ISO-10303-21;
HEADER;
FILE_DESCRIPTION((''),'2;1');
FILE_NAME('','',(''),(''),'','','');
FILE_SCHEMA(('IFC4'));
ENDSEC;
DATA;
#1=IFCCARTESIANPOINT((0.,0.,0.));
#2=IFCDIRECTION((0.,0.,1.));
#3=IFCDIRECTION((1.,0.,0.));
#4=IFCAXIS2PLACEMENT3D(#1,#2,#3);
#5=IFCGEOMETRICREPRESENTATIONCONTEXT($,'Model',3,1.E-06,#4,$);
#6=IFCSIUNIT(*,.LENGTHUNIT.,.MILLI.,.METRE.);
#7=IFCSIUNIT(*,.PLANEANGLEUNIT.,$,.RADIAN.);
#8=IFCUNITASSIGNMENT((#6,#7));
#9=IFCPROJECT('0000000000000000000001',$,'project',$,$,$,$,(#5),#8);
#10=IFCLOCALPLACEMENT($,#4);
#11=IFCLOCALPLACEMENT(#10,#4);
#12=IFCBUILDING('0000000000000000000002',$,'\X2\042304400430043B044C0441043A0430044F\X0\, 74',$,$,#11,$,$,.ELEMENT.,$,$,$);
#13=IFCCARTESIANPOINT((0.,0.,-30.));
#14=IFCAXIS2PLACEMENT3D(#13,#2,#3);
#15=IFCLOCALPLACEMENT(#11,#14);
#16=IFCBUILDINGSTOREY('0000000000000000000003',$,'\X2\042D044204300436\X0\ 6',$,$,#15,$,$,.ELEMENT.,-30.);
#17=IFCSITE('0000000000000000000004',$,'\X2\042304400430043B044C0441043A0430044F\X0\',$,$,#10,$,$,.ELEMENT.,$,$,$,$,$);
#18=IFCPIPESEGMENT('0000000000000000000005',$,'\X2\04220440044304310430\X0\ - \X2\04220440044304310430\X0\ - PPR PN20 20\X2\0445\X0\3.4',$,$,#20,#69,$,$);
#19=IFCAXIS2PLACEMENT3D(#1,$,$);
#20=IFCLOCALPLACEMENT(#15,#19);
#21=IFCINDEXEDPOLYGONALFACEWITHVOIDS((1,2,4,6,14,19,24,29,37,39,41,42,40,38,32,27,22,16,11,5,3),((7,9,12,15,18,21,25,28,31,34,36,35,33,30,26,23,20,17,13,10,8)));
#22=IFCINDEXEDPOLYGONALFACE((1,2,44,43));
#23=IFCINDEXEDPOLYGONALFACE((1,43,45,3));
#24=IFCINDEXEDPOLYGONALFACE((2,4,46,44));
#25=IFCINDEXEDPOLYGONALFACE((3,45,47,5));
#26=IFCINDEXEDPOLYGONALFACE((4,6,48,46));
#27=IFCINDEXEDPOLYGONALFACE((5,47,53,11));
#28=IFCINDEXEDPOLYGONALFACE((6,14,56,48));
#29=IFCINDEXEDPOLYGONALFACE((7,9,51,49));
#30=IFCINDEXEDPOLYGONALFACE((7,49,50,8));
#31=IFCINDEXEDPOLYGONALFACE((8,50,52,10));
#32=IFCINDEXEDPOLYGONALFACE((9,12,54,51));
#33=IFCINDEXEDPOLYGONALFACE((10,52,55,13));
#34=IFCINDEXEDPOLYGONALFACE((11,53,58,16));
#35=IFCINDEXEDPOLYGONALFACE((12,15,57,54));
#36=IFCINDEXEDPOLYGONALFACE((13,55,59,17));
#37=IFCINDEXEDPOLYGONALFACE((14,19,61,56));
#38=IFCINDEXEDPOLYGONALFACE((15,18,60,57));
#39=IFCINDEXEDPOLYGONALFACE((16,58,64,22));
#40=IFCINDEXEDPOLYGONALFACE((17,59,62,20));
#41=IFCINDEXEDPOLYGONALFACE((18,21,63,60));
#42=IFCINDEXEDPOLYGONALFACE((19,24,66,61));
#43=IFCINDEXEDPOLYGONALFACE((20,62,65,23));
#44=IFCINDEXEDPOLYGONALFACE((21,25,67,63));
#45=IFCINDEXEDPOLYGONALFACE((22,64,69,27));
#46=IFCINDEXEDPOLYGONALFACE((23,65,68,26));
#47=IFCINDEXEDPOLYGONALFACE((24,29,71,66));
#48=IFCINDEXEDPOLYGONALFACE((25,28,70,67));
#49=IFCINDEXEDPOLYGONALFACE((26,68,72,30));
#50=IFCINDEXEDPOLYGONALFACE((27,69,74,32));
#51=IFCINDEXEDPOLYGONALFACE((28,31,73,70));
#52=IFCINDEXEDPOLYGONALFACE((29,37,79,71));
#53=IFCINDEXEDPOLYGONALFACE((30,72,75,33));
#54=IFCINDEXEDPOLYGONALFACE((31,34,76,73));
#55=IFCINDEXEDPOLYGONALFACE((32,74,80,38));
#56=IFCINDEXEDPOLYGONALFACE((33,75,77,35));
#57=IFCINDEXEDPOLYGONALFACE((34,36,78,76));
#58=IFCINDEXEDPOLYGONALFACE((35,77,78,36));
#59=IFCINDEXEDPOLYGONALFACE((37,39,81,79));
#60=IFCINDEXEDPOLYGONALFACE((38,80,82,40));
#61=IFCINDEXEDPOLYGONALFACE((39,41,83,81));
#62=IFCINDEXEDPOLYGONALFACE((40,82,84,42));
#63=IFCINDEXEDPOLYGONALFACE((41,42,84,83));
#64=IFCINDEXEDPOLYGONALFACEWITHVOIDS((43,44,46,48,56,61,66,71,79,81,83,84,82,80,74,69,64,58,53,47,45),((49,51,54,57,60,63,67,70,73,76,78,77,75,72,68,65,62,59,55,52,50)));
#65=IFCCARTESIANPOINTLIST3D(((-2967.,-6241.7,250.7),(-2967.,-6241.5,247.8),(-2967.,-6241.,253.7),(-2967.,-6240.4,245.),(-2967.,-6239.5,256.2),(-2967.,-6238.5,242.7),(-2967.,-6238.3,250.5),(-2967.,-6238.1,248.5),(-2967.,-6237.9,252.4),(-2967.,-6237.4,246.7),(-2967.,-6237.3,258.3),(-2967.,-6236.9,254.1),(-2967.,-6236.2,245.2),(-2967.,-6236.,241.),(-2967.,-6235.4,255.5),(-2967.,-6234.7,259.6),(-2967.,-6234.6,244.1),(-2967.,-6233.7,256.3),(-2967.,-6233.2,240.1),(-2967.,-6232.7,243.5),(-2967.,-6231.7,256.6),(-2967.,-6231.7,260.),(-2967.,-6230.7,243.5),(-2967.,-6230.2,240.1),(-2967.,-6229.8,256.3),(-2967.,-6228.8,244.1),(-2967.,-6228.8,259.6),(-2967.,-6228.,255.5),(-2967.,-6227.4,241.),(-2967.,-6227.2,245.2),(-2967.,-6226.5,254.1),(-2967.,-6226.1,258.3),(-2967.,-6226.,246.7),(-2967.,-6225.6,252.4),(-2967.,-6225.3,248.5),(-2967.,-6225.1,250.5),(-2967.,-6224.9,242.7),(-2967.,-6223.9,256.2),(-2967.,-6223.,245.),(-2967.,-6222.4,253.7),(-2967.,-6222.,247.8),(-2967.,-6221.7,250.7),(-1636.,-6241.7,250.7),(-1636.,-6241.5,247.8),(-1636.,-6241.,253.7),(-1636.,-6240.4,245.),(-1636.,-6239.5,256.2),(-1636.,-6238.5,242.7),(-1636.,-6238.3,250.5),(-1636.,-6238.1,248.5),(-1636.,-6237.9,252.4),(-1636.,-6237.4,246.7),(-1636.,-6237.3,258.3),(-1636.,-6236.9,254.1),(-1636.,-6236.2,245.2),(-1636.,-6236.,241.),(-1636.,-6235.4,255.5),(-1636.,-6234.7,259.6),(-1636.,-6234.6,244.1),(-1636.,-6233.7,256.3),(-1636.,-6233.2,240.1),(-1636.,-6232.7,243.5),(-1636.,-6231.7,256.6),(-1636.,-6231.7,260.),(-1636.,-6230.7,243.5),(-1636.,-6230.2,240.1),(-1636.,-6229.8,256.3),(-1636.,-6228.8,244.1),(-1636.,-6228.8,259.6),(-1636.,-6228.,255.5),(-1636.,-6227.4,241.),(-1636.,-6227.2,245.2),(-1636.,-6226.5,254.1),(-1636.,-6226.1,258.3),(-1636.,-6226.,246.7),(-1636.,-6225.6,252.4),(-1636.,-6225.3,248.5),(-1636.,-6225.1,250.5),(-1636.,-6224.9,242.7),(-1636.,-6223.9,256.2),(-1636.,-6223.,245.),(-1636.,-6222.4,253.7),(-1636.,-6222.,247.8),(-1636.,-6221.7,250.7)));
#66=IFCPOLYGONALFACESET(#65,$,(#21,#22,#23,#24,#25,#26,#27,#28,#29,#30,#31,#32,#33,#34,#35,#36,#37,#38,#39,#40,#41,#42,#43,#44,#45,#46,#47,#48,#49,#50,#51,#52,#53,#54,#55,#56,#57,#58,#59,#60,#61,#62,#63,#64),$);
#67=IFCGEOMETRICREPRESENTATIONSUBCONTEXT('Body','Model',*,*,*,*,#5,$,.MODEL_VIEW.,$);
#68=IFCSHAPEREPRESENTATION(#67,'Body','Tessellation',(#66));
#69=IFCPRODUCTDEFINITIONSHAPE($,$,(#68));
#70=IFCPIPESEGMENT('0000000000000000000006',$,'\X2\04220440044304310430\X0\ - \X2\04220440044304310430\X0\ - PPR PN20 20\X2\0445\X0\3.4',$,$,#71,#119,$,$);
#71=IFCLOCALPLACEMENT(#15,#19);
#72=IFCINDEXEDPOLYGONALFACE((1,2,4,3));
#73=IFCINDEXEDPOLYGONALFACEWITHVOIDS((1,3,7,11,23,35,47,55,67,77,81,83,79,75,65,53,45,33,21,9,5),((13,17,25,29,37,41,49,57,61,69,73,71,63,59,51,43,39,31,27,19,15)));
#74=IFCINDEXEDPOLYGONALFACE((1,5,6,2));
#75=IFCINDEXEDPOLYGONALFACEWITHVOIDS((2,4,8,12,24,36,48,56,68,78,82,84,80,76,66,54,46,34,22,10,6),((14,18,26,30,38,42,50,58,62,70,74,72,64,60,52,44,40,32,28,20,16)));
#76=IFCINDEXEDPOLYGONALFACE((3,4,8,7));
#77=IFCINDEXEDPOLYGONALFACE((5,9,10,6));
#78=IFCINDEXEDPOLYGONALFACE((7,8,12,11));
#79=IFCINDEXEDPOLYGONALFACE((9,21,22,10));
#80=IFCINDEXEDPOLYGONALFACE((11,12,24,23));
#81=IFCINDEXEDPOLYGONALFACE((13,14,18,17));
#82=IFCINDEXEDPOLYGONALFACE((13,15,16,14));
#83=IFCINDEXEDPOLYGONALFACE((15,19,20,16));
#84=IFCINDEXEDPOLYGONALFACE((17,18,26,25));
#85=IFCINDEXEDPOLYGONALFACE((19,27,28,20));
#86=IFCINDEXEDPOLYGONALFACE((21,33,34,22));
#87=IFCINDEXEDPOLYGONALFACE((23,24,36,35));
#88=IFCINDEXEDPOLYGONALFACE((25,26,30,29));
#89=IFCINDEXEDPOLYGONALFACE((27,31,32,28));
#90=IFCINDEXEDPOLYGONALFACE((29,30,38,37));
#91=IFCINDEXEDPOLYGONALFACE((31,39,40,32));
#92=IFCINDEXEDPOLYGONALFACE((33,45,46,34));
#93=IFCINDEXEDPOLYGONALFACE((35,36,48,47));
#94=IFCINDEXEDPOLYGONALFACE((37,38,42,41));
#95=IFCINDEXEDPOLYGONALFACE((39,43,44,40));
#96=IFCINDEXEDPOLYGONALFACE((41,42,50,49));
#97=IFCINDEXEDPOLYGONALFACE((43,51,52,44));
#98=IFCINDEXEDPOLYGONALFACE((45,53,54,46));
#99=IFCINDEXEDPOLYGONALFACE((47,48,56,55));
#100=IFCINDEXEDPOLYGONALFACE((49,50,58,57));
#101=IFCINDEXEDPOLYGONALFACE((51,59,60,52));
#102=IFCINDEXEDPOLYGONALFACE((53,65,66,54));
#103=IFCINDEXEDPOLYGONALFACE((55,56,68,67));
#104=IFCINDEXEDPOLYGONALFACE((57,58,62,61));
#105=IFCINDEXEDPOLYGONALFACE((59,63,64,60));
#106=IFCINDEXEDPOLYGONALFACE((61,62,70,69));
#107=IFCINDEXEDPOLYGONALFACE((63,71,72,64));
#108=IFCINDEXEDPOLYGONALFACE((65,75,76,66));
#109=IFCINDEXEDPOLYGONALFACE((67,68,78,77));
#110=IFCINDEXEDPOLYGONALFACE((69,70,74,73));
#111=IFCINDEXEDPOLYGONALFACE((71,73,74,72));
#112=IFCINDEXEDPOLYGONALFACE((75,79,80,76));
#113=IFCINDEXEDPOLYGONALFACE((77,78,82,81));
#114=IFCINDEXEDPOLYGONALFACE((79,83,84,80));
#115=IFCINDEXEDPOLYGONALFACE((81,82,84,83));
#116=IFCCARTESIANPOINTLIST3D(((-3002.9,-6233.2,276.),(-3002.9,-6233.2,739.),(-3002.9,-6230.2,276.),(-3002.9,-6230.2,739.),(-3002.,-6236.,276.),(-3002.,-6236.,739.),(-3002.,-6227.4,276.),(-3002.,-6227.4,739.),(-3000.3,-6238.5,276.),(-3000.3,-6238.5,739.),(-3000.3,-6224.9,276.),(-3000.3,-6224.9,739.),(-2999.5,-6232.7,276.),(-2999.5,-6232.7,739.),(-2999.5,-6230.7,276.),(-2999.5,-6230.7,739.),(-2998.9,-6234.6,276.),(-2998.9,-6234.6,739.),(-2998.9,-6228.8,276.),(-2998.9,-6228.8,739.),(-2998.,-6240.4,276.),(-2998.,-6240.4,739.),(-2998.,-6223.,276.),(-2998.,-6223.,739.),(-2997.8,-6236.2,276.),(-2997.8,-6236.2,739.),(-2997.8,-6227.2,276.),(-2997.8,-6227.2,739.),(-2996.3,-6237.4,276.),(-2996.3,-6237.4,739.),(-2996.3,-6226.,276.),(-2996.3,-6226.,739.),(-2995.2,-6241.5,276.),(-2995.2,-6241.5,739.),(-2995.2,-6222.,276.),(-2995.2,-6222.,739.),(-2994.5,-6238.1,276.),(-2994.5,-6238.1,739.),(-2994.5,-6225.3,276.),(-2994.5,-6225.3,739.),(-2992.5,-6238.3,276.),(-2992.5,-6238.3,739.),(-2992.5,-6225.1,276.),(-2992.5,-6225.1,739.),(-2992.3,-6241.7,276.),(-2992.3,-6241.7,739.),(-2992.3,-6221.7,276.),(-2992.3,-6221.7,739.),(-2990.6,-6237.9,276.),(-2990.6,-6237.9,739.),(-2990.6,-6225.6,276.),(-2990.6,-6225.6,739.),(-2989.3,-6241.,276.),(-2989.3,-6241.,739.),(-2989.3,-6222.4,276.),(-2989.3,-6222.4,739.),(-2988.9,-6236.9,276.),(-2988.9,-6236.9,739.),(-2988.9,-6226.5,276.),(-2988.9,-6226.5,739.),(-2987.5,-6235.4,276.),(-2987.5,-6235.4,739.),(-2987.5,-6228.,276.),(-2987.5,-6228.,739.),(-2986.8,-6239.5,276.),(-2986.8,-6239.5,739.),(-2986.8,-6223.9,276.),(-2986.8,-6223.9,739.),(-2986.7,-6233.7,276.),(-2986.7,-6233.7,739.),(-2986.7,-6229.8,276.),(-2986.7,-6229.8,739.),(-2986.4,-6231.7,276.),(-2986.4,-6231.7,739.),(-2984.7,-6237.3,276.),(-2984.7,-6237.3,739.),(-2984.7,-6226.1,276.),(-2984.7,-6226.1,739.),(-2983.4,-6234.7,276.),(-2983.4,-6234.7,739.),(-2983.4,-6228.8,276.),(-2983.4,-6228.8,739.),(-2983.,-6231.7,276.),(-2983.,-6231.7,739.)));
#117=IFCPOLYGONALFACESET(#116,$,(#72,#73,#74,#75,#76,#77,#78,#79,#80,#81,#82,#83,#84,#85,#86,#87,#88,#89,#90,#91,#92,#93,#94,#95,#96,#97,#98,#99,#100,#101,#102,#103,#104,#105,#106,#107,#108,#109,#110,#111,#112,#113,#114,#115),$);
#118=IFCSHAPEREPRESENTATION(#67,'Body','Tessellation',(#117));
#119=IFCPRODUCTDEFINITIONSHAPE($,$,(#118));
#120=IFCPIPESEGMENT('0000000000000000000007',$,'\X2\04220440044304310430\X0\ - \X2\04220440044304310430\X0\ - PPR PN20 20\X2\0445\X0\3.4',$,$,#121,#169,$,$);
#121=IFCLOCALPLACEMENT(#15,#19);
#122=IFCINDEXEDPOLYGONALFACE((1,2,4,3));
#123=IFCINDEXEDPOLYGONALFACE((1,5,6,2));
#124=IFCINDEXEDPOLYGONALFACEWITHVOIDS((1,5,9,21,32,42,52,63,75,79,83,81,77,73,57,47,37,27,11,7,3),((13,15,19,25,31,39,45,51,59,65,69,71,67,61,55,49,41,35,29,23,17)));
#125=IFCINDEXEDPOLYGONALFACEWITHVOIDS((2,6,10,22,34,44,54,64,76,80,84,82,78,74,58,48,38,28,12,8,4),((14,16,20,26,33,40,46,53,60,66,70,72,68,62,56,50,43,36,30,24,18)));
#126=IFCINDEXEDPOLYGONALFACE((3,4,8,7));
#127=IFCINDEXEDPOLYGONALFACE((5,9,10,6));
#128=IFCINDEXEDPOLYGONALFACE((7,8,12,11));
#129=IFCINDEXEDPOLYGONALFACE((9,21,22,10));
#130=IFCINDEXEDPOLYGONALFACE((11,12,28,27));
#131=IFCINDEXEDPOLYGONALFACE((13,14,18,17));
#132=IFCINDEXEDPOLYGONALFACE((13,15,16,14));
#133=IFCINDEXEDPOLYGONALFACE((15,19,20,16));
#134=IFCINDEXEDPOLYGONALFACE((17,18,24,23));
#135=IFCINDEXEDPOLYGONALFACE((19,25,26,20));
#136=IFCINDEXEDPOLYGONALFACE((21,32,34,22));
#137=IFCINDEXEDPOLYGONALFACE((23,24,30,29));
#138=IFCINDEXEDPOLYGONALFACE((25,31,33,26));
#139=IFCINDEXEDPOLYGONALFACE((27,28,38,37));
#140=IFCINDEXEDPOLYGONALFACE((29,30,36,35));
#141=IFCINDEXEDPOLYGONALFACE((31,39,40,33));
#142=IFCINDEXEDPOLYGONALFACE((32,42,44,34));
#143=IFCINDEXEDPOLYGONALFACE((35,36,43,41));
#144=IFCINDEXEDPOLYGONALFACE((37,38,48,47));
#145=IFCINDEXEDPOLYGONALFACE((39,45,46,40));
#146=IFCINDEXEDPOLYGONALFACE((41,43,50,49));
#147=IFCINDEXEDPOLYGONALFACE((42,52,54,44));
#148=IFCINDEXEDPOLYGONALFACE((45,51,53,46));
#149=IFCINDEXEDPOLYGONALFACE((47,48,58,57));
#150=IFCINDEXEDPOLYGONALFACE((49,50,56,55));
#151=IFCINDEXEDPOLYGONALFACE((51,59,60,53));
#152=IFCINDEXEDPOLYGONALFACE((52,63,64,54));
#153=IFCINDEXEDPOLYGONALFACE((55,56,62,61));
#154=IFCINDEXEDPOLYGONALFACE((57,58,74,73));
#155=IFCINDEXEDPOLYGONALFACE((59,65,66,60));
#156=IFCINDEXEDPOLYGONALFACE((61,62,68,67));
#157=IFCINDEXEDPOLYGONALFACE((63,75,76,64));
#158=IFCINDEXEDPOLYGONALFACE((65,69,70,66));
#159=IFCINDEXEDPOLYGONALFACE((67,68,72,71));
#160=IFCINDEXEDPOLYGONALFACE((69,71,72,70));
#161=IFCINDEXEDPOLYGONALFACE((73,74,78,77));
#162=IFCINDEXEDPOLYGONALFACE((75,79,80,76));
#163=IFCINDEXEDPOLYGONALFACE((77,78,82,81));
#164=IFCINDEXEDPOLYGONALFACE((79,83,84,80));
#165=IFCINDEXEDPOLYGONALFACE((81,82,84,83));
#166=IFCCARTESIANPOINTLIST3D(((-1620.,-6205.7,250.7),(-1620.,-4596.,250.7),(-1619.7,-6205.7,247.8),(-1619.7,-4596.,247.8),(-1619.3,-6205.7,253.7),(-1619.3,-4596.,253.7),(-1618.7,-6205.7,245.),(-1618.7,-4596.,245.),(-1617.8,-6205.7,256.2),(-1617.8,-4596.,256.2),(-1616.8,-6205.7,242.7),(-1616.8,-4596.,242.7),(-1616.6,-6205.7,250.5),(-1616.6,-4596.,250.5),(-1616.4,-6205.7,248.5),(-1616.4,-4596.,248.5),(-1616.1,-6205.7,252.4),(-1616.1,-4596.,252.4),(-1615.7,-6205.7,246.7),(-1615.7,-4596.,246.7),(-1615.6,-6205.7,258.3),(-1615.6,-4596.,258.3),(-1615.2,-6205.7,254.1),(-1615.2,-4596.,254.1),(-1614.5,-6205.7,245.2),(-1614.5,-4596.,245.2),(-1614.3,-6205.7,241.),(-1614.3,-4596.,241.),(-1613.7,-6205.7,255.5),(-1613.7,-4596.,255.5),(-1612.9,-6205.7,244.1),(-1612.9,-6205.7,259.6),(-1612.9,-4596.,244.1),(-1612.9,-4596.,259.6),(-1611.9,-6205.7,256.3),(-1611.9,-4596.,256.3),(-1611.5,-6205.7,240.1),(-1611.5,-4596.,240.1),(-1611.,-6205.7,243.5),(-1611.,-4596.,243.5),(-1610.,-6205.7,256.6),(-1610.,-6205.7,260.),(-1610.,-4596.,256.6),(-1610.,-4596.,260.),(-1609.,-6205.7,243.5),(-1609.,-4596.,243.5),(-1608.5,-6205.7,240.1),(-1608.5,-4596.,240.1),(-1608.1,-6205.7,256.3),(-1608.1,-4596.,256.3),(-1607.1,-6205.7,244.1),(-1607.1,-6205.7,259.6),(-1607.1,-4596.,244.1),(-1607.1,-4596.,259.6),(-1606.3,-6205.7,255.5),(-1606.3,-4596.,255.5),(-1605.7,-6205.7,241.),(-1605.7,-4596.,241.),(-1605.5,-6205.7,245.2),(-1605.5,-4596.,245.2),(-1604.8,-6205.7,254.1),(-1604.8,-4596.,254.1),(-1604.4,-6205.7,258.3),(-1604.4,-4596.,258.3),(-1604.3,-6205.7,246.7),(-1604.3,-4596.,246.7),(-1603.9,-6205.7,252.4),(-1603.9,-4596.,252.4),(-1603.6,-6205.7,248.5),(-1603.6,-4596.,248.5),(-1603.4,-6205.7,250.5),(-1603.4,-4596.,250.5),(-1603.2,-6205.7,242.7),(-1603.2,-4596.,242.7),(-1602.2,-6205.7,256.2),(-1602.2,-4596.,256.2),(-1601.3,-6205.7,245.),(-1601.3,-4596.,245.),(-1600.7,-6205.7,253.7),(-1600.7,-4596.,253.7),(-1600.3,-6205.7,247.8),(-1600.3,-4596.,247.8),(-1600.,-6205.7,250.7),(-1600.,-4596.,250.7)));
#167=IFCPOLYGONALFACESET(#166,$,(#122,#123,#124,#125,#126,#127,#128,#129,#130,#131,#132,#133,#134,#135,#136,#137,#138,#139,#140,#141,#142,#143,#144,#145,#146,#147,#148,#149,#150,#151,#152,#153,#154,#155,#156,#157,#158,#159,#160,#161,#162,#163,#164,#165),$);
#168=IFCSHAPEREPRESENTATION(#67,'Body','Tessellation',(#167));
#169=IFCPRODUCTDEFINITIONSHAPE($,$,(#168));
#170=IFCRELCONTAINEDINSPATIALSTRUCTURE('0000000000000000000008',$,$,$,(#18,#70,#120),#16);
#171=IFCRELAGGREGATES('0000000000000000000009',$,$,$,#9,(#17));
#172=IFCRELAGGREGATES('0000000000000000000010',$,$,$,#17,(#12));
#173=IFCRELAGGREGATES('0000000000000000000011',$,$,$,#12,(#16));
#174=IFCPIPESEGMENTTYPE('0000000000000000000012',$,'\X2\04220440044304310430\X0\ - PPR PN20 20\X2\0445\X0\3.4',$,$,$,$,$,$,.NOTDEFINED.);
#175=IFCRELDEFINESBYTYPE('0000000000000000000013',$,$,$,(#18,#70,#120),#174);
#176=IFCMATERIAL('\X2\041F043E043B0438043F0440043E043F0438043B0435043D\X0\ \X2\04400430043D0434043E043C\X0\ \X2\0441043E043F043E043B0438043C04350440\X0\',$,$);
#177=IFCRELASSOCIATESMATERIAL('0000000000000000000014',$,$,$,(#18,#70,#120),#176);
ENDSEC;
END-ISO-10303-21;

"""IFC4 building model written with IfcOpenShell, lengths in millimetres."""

from ifc_helpers import new_model, entity, si_unit, frame, origin_with_axes, place, context, subcontext, project, spatial, material, type_object, element, save


model = new_model("IFC4")

# Units and contexts
model_context = context("Model", 3, precision=1e-06, world=origin_with_axes())
body_context = subcontext(model_context, "Body", "Model", "MODEL_VIEW")
ifc_project = project(units=[si_unit("LENGTHUNIT", "METRE", prefix="MILLI"), si_unit("PLANEANGLEUNIT", "RADIAN")], contexts=[model_context])

# Site, building, storey
site_placement = place(None, origin_with_axes())
site = spatial("IfcSite", under=ifc_project, at=site_placement, Name="Уральская", CompositionType="ELEMENT")
building_placement = place(site_placement, origin_with_axes())
building = spatial("IfcBuilding", under=site, at=building_placement, Name="Уральская, 74", CompositionType="ELEMENT")
storey_placement = place(building_placement, frame((0.0, 0.0, -30.0), z_axis=(0.0, 0.0, 1.0), x_axis=(1.0, 0.0, 0.0)))
storey = spatial("IfcBuildingStorey", under=building, at=storey_placement, Name="Этаж 6", CompositionType="ELEMENT", Elevation=-30.0)

# Pipe segments
ifc_material_1 = material(Name="Полипропилен рандом сополимер")
pipe_segment_type_1 = type_object("IfcPipeSegmentType", Name="Труба - PPR PN20 20х3.4", PredefinedType="NOTDEFINED")
pipe_segment_1_placement = place(storey_placement, frame((-2967.0, -6231.7, 250.0), z_axis=(0.0, 0.0, 1.0), x_axis=(1.0, 0.0, 0.0)))
element("IfcPipeSegment", 1, at=pipe_segment_1_placement, inside=storey, type_object=pipe_segment_type_1, material=ifc_material_1, Name="Труба - Труба - PPR PN20 20х3.4", context=body_context, shape_type="AdvancedSweptSolid", body=[
    entity("IfcSweptDiskSolid", entity("IfcIndexedPolyCurve", entity("IfcCartesianPointList3D", [[0.0, 0.0, 0.0], [1331.0, 0.0, 0.0]]), [entity("IfcLineIndex", [1, 2])]), 10.0, 6.6),
])
pipe_segment_2_placement = place(storey_placement, frame((-2993.0, -6231.7, 739.0), z_axis=(0.0, 0.0, 1.0), x_axis=(-1.0, 0.0, 0.0)))
element("IfcPipeSegment", 2, at=pipe_segment_2_placement, inside=storey, type_object=pipe_segment_type_1, material=ifc_material_1, Name="Труба - Труба - PPR PN20 20х3.4", context=body_context, shape_type="AdvancedSweptSolid", body=[
    entity("IfcSweptDiskSolid", entity("IfcIndexedPolyCurve", entity("IfcCartesianPointList3D", [[0.0, 0.0, 0.0], [0.0, 0.0, -463.0]]), [entity("IfcLineIndex", [1, 2])]), 10.0, 6.6),
])
pipe_segment_3_placement = place(storey_placement, frame((-1610.0, -6205.7, 250.0), z_axis=(0.0, 0.0, 1.0), x_axis=(0.0, 1.0, 0.0)))
element("IfcPipeSegment", 3, at=pipe_segment_3_placement, inside=storey, type_object=pipe_segment_type_1, material=ifc_material_1, Name="Труба - Труба - PPR PN20 20х3.4", context=body_context, shape_type="AdvancedSweptSolid", body=[
    entity("IfcSweptDiskSolid", entity("IfcIndexedPolyCurve", entity("IfcCartesianPointList3D", [[0.0, 0.0, 0.0], [1609.7, 0.0, 0.0]]), [entity("IfcLineIndex", [1, 2])]), 10.0, 6.6),
])

save(model, "model.ifc")
